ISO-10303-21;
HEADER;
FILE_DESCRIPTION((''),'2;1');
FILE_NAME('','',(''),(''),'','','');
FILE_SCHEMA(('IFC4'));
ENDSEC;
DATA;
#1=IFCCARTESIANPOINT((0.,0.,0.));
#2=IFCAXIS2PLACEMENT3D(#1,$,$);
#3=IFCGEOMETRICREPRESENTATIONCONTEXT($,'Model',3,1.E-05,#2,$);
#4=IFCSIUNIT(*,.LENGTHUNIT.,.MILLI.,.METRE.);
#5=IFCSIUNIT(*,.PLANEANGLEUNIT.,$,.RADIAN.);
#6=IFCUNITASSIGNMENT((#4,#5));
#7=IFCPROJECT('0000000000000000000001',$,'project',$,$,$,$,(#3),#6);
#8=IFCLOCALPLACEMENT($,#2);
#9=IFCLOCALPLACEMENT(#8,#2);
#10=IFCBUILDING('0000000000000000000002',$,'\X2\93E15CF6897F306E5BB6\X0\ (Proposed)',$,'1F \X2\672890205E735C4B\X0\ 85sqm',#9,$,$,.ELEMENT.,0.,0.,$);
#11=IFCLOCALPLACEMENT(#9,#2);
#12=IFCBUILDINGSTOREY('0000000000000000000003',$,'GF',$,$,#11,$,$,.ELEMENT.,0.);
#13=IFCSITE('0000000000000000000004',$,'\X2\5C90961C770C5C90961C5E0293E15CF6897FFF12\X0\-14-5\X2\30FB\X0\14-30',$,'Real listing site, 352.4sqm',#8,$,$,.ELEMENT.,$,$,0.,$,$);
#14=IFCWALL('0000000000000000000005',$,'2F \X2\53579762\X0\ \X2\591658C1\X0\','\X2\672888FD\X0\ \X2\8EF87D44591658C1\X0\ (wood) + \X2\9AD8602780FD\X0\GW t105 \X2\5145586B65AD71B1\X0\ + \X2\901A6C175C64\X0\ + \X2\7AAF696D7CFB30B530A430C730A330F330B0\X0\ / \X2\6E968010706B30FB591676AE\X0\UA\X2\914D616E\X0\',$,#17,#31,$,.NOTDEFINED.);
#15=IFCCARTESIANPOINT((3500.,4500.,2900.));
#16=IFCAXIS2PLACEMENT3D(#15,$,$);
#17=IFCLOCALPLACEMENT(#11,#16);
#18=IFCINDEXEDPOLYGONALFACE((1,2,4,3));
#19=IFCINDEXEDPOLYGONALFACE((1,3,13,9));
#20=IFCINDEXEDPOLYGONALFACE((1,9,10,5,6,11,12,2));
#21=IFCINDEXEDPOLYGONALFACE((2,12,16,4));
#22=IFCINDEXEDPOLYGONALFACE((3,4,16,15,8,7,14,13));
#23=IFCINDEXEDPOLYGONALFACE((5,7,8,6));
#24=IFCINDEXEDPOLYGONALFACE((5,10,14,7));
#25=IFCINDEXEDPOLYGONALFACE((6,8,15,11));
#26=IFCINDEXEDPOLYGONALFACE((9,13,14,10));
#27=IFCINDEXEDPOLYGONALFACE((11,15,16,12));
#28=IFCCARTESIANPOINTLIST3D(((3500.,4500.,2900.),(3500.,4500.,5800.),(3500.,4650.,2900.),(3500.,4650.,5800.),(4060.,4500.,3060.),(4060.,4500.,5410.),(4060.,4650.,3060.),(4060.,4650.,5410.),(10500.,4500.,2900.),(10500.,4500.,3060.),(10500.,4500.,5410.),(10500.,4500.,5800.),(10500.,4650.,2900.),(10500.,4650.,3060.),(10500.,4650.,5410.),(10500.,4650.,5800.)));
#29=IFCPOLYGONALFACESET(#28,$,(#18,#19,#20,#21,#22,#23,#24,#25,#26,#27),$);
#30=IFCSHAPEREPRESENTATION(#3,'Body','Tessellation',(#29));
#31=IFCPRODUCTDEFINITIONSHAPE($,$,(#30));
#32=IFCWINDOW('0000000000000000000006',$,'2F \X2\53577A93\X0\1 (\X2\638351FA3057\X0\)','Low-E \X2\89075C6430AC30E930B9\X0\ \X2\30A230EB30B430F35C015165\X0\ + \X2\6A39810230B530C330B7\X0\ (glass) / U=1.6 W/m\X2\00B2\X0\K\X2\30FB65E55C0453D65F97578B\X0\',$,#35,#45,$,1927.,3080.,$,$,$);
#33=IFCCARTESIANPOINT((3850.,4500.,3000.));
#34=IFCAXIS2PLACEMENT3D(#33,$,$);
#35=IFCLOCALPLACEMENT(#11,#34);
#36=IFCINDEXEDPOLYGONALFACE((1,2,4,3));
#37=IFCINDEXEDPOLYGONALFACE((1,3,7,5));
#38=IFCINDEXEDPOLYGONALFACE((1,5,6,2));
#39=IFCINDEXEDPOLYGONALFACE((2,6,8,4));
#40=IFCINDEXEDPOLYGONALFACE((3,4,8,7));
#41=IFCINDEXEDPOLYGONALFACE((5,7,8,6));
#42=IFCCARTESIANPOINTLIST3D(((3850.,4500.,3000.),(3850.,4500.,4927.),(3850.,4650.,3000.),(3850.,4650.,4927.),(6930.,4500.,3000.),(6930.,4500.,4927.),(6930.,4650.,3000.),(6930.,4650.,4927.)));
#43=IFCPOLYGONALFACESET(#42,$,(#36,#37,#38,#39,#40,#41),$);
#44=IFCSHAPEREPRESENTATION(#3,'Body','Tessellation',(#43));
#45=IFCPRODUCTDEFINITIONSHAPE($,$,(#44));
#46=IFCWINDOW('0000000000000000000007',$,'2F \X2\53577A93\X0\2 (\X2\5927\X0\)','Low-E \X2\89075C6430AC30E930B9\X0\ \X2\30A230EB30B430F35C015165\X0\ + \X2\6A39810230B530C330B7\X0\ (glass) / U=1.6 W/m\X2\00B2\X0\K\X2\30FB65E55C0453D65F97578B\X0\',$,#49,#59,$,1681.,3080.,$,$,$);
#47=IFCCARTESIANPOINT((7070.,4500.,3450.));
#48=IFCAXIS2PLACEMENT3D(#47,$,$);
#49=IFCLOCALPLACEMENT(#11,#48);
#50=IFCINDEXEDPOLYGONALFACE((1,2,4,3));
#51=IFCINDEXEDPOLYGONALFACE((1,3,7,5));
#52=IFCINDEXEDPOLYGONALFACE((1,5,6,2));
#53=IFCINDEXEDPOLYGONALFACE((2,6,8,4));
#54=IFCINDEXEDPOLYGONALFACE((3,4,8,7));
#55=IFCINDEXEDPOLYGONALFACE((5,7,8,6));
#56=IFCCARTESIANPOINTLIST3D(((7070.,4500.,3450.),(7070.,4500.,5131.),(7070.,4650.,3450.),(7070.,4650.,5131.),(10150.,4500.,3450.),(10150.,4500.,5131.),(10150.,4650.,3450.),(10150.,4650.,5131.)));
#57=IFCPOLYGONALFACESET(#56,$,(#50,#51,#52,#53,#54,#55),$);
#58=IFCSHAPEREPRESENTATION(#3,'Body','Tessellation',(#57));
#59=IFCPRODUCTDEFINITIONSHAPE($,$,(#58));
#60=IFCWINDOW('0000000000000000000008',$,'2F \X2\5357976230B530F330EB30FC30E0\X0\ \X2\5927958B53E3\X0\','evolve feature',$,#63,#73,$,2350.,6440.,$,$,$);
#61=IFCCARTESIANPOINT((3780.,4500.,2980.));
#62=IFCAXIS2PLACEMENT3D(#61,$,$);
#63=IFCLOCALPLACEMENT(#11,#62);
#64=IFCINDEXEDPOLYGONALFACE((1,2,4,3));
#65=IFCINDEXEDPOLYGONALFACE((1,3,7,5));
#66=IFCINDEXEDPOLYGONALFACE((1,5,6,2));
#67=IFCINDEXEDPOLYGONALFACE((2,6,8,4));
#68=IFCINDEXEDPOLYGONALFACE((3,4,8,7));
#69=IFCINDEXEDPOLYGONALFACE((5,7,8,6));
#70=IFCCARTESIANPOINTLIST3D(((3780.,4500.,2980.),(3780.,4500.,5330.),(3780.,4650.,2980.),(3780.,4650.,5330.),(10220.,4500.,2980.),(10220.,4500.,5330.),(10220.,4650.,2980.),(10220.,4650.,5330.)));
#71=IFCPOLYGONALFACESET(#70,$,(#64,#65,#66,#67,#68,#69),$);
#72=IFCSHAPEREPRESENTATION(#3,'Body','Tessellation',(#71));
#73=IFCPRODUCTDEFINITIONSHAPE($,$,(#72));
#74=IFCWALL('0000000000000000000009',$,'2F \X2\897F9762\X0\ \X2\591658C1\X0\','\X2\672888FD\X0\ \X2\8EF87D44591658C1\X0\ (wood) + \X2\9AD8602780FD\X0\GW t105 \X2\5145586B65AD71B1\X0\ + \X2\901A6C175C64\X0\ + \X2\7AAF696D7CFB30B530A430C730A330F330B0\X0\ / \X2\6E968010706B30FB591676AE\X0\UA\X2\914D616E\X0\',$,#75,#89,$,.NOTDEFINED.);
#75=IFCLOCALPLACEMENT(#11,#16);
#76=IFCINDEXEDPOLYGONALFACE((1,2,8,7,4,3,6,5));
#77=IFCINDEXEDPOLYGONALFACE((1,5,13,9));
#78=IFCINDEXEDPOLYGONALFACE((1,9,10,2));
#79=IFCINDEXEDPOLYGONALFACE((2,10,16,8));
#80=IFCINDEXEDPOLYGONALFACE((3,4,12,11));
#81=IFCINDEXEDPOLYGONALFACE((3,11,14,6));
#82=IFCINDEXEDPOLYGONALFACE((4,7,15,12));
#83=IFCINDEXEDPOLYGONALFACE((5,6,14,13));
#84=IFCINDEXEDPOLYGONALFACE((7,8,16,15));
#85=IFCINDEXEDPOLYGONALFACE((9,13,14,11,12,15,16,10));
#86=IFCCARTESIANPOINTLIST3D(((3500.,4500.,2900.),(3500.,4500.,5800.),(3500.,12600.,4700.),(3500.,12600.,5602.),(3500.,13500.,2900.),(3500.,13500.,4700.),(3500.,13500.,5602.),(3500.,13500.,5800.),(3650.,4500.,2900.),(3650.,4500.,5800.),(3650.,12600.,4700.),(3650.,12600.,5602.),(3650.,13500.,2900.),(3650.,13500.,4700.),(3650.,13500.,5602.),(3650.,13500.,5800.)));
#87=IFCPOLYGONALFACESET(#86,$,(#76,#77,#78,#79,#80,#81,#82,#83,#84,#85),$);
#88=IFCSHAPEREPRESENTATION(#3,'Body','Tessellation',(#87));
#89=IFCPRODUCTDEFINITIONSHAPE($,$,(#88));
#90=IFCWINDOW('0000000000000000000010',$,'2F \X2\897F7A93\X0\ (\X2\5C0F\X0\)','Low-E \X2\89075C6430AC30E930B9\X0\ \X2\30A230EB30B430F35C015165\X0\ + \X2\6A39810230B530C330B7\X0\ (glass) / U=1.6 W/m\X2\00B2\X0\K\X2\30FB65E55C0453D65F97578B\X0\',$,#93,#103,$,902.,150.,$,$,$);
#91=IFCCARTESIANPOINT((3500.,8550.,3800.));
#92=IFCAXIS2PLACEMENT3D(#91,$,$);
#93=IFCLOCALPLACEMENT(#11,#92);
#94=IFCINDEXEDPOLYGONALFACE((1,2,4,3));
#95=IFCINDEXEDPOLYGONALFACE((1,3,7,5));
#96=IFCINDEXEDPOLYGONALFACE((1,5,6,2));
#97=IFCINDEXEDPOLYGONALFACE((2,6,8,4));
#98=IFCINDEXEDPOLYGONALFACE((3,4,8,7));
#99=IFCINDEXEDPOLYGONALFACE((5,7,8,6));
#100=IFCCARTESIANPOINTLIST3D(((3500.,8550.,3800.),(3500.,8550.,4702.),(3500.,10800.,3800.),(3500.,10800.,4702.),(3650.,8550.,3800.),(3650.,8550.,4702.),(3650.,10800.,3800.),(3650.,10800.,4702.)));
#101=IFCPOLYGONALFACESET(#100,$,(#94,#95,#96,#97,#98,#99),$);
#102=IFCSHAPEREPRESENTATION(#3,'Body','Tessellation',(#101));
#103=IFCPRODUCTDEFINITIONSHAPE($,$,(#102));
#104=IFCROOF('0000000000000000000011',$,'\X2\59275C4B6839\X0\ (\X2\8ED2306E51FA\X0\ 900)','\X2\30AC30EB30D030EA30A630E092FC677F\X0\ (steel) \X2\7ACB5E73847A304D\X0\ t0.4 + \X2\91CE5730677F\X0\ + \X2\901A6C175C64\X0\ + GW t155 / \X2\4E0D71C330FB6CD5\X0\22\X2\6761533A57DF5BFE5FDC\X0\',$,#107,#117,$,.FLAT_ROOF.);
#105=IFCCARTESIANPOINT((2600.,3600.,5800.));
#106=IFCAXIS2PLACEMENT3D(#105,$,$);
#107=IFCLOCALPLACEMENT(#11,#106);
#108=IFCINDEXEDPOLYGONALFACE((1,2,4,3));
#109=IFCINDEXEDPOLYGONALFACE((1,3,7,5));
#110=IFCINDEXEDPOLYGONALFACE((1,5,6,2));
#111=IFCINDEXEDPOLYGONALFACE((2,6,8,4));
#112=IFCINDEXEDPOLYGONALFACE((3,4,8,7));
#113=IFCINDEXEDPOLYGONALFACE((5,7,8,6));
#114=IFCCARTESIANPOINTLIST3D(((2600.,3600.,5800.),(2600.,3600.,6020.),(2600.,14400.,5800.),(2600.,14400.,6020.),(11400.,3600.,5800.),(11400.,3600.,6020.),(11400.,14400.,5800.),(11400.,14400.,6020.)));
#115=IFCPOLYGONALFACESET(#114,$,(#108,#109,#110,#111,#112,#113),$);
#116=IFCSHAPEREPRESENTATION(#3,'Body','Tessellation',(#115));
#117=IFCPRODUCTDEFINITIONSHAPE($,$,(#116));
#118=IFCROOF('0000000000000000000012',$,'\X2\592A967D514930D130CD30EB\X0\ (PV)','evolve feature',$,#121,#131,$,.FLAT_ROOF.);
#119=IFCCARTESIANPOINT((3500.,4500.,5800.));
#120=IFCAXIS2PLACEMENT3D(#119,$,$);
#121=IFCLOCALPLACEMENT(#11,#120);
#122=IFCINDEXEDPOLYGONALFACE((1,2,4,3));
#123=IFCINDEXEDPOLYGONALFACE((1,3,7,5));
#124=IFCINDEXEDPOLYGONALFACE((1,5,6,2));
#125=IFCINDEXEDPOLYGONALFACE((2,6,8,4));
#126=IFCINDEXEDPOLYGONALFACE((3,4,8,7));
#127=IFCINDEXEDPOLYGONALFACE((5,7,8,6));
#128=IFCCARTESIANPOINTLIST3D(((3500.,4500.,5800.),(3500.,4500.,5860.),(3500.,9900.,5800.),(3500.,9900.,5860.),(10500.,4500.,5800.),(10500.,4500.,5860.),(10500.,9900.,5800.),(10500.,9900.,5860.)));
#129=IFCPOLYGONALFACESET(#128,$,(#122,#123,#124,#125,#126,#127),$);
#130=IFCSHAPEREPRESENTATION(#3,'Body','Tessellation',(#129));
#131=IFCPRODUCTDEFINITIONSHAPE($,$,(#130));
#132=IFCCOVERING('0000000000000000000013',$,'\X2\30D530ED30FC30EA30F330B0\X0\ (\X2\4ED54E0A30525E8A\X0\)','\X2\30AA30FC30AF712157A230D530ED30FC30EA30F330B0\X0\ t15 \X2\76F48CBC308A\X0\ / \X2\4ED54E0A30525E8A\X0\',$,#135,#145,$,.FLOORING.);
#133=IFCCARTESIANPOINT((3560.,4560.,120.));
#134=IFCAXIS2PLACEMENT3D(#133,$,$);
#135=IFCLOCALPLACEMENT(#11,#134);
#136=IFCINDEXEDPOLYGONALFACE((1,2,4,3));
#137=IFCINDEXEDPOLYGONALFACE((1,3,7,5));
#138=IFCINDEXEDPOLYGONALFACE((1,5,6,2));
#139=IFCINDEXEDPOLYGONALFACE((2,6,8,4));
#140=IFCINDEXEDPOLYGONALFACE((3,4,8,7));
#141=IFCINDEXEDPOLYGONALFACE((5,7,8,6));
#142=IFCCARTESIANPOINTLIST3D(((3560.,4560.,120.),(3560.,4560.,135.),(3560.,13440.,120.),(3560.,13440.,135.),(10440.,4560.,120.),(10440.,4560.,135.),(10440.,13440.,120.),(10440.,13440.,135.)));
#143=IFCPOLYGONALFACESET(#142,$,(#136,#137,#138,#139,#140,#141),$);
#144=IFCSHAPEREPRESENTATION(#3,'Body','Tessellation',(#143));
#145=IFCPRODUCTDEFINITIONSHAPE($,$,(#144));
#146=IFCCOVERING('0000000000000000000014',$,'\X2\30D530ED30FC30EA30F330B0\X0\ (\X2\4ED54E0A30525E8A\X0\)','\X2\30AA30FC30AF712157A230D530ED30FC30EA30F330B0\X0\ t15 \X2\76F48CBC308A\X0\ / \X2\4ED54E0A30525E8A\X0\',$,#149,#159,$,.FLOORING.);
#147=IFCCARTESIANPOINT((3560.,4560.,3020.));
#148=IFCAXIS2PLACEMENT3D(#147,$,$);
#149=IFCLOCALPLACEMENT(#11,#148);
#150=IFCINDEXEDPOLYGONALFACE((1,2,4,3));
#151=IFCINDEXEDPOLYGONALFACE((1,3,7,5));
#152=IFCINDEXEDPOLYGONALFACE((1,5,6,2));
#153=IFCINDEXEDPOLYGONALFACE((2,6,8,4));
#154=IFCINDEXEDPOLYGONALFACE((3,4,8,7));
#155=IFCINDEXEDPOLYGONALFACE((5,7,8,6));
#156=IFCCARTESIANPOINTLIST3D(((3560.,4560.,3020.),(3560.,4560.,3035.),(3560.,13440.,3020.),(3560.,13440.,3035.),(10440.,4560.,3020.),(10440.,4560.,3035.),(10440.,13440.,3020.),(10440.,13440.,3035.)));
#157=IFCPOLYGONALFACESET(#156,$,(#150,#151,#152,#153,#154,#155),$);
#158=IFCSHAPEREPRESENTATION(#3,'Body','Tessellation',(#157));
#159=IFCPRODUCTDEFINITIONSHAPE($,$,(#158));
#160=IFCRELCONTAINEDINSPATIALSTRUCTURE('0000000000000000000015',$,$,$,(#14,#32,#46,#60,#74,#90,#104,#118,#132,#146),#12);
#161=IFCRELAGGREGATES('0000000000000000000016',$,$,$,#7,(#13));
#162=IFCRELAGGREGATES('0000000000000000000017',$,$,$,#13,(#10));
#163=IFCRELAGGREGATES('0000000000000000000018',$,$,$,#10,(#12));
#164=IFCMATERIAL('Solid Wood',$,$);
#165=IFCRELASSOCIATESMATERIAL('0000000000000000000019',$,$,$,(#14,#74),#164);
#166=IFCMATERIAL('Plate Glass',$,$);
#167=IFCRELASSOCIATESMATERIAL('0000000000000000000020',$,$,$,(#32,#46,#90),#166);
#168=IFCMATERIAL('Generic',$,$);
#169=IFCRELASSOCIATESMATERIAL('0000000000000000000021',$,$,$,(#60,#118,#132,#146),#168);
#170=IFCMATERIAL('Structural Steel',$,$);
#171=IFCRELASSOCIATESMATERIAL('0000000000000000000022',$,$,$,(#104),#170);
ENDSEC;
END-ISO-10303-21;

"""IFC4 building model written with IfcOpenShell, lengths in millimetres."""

from ifc_helpers import new_model, si_unit, frame, frame_2d, origin, place, context, project, spatial, rectangle, extrude, material, element, fill, save


model = new_model("IFC4")

# Units and contexts
model_context = context("Model", 3, precision=1e-05, world=origin())
ifc_project = project(units=[si_unit("LENGTHUNIT", "METRE", prefix="MILLI"), si_unit("PLANEANGLEUNIT", "RADIAN")], contexts=[model_context])

# Site, building, storey
site_placement = place(None, origin())
site = spatial("IfcSite", under=ifc_project, at=site_placement, Name="岐阜県岐阜市鏡島西２-14-5・14-30", ObjectType="Real listing site, 352.4sqm", CompositionType="ELEMENT", RefElevation=0.0)
building_placement = place(site_placement, origin())
building = spatial("IfcBuilding", under=site, at=building_placement, Name="鏡島西の家 (Proposed)", ObjectType="1F 木造平屋 85sqm", CompositionType="ELEMENT", ElevationOfRefHeight=0.0, ElevationOfTerrain=0.0)
storey_placement = place(building_placement, origin())
storey = spatial("IfcBuildingStorey", under=building, at=storey_placement, Name="GF", CompositionType="ELEMENT", Elevation=0.0)

# Shared definitions
ifc_material_1 = material(Name="Solid Wood")
ifc_material_2 = material(Name="Generic")

# Shared definitions
ifc_material_3 = material(Name="Plate Glass")

# Wall, openings, windows
wall_1_placement = place(storey_placement, frame((3500.0, 4500.0, 2900.0)))
wall_1 = element("IfcWall", 1, at=wall_1_placement, inside=storey, material=ifc_material_1, Name="2F 南面 外壁", Description="木製 軸組外壁 (wood) + 高性能GW t105 充填断熱 + 通気層 + 窯業系サイディング / 準耐火・外皮UA配慮", PredefinedType="NOTDEFINED", context=model_context, shape_type="SweptSolid", body=[
    extrude(rectangle(XDim=7000.0, YDim=150.0, at=frame_2d((3500.0, 75.0))), frame((3500.0, 4500.0, 2900.0)), (0.0, 0.0, 1.0), 2900.0),
])
opening_1_placement = place(storey_placement, frame((3850.0, 4500.0, 3000.0)))
opening_1 = element("IfcOpeningElement", 2, at=opening_1_placement, cuts=wall_1, PredefinedType="NOTDEFINED", context=model_context, shape_type="SweptSolid", body=[
    extrude(rectangle(XDim=3080.0, YDim=150.0, at=frame_2d((1540.0, 75.0))), frame((3850.0, 4500.0, 3000.0)), (0.0, 0.0, 1.0), 1927.0),
])
opening_2_placement = place(storey_placement, frame((7070.0, 4500.0, 3450.0)))
opening_2 = element("IfcOpeningElement", 3, at=opening_2_placement, cuts=wall_1, PredefinedType="NOTDEFINED", context=model_context, shape_type="SweptSolid", body=[
    extrude(rectangle(XDim=3080.0, YDim=150.0, at=frame_2d((1540.0, 75.0))), frame((7070.0, 4500.0, 3450.0)), (0.0, 0.0, 1.0), 1681.0),
])
opening_3_placement = place(storey_placement, frame((3780.0, 4500.0, 2980.0)))
opening_3 = element("IfcOpeningElement", 4, at=opening_3_placement, cuts=wall_1, PredefinedType="NOTDEFINED", context=model_context, shape_type="SweptSolid", body=[
    extrude(rectangle(XDim=6440.0, YDim=150.0, at=frame_2d((3220.0, 75.0))), frame((3780.0, 4500.0, 2980.0)), (0.0, 0.0, 1.0), 2350.0),
])
window_1_placement = place(storey_placement, frame((3850.0, 4500.0, 3000.0)))
window_1 = element("IfcWindow", 5, at=window_1_placement, inside=storey, material=ifc_material_3, Name="2F 南窓1 (掃出し)", Description="Low-E 複層ガラス アルゴン封入 + 樹脂サッシ (glass) / U=1.6 W/m²K・日射取得型", OverallHeight=1927.0, OverallWidth=3080.0, context=model_context, shape_type="SweptSolid", body=[
    extrude(rectangle(XDim=3080.0, YDim=150.0, at=frame_2d((1540.0, 75.0))), frame((3850.0, 4500.0, 3000.0)), (0.0, 0.0, 1.0), 1927.0),
])
fill(opening_1, window_1)
window_2_placement = place(storey_placement, frame((7070.0, 4500.0, 3450.0)))
window_2 = element("IfcWindow", 6, at=window_2_placement, inside=storey, material=ifc_material_3, Name="2F 南窓2 (大)", Description="Low-E 複層ガラス アルゴン封入 + 樹脂サッシ (glass) / U=1.6 W/m²K・日射取得型", OverallHeight=1681.0, OverallWidth=3080.0, context=model_context, shape_type="SweptSolid", body=[
    extrude(rectangle(XDim=3080.0, YDim=150.0, at=frame_2d((1540.0, 75.0))), frame((7070.0, 4500.0, 3450.0)), (0.0, 0.0, 1.0), 1681.0),
])
fill(opening_2, window_2)
window_3_placement = place(storey_placement, frame((3780.0, 4500.0, 2980.0)))
window_3 = element("IfcWindow", 7, at=window_3_placement, inside=storey, material=ifc_material_2, Name="2F 南面サンルーム 大開口", Description="evolve feature", OverallHeight=2350.0, OverallWidth=6440.0, context=model_context, shape_type="SweptSolid", body=[
    extrude(rectangle(XDim=6440.0, YDim=150.0, at=frame_2d((3220.0, 75.0))), frame((3780.0, 4500.0, 2980.0)), (0.0, 0.0, 1.0), 2350.0),
])
fill(opening_3, window_3)

# Wall, opening, window
wall_2_placement = place(storey_placement, frame((3500.0, 4500.0, 2900.0)))
wall_2 = element("IfcWall", 8, at=wall_2_placement, inside=storey, material=ifc_material_1, Name="2F 西面 外壁", Description="木製 軸組外壁 (wood) + 高性能GW t105 充填断熱 + 通気層 + 窯業系サイディング / 準耐火・外皮UA配慮", PredefinedType="NOTDEFINED", context=model_context, shape_type="SweptSolid", body=[
    extrude(rectangle(XDim=150.0, YDim=9000.0, at=frame_2d((75.0, 4500.0))), frame((3500.0, 4500.0, 2900.0)), (0.0, 0.0, 1.0), 2900.0),
])
opening_4_placement = place(storey_placement, frame((3500.0, 8550.0, 3800.0)))
opening_4 = element("IfcOpeningElement", 9, at=opening_4_placement, cuts=wall_2, PredefinedType="NOTDEFINED", context=model_context, shape_type="SweptSolid", body=[
    extrude(rectangle(XDim=150.0, YDim=2250.0, at=frame_2d((75.0, 1125.0))), frame((3500.0, 8550.0, 3800.0)), (0.0, 0.0, 1.0), 902.0),
])
window_4_placement = place(storey_placement, frame((3500.0, 8550.0, 3800.0)))
window_4 = element("IfcWindow", 10, at=window_4_placement, inside=storey, material=ifc_material_3, Name="2F 西窓 (小)", Description="Low-E 複層ガラス アルゴン封入 + 樹脂サッシ (glass) / U=1.6 W/m²K・日射取得型", OverallHeight=902.0, OverallWidth=150.0, context=model_context, shape_type="SweptSolid", body=[
    extrude(rectangle(XDim=150.0, YDim=2250.0, at=frame_2d((75.0, 1125.0))), frame((3500.0, 8550.0, 3800.0)), (0.0, 0.0, 1.0), 902.0),
])
fill(opening_4, window_4)

# Roofs
ifc_material_4 = material(Name="Structural Steel")
roof_1_placement = place(storey_placement, frame((2600.0, 3600.0, 5800.0)))
element("IfcRoof", 11, at=roof_1_placement, inside=storey, material=ifc_material_4, Name="大屋根 (軒の出 900)", Description="ガルバリウム鋼板 (steel) 立平葺き t0.4 + 野地板 + 通気層 + GW t155 / 不燃・法22条区域対応", PredefinedType="FLAT_ROOF", context=model_context, shape_type="SweptSolid", body=[
    extrude(rectangle(XDim=8800.0, YDim=10800.0, at=frame_2d((4400.0, 5400.0))), frame((2600.0, 3600.0, 5800.0)), (0.0, 0.0, 1.0), 220.0),
])
roof_2_placement = place(storey_placement, frame((3500.0, 4500.0, 5800.0)))
element("IfcRoof", 12, at=roof_2_placement, inside=storey, material=ifc_material_2, Name="太陽光パネル (PV)", Description="evolve feature", PredefinedType="FLAT_ROOF", context=model_context, shape_type="SweptSolid", body=[
    extrude(rectangle(XDim=7000.0, YDim=5400.0, at=frame_2d((3500.0, 2700.0))), frame((3500.0, 4500.0, 5800.0)), (0.0, 0.0, 1.0), 60.0),
])

# Coverings
covering_1_placement = place(storey_placement, frame((3560.0, 4560.0, 120.0)))
element("IfcCovering", 13, at=covering_1_placement, inside=storey, material=ifc_material_2, Name="フローリング (仕上げ床)", Description="オーク無垢フローリング t15 直貼り / 仕上げ床", PredefinedType="FLOORING", context=model_context, shape_type="SweptSolid", body=[
    extrude(rectangle(XDim=6880.0, YDim=8880.0, at=frame_2d((3440.0, 4440.0))), frame((3560.0, 4560.0, 120.0)), (0.0, 0.0, 1.0), 15.0),
])
covering_2_placement = place(storey_placement, frame((3560.0, 4560.0, 3020.0)))
element("IfcCovering", 14, at=covering_2_placement, inside=storey, material=ifc_material_2, Name="フローリング (仕上げ床)", Description="オーク無垢フローリング t15 直貼り / 仕上げ床", PredefinedType="FLOORING", context=model_context, shape_type="SweptSolid", body=[
    extrude(rectangle(XDim=6880.0, YDim=8880.0, at=frame_2d((3440.0, 4440.0))), frame((3560.0, 4560.0, 3020.0)), (0.0, 0.0, 1.0), 15.0),
])

save(model, "model.ifc")
